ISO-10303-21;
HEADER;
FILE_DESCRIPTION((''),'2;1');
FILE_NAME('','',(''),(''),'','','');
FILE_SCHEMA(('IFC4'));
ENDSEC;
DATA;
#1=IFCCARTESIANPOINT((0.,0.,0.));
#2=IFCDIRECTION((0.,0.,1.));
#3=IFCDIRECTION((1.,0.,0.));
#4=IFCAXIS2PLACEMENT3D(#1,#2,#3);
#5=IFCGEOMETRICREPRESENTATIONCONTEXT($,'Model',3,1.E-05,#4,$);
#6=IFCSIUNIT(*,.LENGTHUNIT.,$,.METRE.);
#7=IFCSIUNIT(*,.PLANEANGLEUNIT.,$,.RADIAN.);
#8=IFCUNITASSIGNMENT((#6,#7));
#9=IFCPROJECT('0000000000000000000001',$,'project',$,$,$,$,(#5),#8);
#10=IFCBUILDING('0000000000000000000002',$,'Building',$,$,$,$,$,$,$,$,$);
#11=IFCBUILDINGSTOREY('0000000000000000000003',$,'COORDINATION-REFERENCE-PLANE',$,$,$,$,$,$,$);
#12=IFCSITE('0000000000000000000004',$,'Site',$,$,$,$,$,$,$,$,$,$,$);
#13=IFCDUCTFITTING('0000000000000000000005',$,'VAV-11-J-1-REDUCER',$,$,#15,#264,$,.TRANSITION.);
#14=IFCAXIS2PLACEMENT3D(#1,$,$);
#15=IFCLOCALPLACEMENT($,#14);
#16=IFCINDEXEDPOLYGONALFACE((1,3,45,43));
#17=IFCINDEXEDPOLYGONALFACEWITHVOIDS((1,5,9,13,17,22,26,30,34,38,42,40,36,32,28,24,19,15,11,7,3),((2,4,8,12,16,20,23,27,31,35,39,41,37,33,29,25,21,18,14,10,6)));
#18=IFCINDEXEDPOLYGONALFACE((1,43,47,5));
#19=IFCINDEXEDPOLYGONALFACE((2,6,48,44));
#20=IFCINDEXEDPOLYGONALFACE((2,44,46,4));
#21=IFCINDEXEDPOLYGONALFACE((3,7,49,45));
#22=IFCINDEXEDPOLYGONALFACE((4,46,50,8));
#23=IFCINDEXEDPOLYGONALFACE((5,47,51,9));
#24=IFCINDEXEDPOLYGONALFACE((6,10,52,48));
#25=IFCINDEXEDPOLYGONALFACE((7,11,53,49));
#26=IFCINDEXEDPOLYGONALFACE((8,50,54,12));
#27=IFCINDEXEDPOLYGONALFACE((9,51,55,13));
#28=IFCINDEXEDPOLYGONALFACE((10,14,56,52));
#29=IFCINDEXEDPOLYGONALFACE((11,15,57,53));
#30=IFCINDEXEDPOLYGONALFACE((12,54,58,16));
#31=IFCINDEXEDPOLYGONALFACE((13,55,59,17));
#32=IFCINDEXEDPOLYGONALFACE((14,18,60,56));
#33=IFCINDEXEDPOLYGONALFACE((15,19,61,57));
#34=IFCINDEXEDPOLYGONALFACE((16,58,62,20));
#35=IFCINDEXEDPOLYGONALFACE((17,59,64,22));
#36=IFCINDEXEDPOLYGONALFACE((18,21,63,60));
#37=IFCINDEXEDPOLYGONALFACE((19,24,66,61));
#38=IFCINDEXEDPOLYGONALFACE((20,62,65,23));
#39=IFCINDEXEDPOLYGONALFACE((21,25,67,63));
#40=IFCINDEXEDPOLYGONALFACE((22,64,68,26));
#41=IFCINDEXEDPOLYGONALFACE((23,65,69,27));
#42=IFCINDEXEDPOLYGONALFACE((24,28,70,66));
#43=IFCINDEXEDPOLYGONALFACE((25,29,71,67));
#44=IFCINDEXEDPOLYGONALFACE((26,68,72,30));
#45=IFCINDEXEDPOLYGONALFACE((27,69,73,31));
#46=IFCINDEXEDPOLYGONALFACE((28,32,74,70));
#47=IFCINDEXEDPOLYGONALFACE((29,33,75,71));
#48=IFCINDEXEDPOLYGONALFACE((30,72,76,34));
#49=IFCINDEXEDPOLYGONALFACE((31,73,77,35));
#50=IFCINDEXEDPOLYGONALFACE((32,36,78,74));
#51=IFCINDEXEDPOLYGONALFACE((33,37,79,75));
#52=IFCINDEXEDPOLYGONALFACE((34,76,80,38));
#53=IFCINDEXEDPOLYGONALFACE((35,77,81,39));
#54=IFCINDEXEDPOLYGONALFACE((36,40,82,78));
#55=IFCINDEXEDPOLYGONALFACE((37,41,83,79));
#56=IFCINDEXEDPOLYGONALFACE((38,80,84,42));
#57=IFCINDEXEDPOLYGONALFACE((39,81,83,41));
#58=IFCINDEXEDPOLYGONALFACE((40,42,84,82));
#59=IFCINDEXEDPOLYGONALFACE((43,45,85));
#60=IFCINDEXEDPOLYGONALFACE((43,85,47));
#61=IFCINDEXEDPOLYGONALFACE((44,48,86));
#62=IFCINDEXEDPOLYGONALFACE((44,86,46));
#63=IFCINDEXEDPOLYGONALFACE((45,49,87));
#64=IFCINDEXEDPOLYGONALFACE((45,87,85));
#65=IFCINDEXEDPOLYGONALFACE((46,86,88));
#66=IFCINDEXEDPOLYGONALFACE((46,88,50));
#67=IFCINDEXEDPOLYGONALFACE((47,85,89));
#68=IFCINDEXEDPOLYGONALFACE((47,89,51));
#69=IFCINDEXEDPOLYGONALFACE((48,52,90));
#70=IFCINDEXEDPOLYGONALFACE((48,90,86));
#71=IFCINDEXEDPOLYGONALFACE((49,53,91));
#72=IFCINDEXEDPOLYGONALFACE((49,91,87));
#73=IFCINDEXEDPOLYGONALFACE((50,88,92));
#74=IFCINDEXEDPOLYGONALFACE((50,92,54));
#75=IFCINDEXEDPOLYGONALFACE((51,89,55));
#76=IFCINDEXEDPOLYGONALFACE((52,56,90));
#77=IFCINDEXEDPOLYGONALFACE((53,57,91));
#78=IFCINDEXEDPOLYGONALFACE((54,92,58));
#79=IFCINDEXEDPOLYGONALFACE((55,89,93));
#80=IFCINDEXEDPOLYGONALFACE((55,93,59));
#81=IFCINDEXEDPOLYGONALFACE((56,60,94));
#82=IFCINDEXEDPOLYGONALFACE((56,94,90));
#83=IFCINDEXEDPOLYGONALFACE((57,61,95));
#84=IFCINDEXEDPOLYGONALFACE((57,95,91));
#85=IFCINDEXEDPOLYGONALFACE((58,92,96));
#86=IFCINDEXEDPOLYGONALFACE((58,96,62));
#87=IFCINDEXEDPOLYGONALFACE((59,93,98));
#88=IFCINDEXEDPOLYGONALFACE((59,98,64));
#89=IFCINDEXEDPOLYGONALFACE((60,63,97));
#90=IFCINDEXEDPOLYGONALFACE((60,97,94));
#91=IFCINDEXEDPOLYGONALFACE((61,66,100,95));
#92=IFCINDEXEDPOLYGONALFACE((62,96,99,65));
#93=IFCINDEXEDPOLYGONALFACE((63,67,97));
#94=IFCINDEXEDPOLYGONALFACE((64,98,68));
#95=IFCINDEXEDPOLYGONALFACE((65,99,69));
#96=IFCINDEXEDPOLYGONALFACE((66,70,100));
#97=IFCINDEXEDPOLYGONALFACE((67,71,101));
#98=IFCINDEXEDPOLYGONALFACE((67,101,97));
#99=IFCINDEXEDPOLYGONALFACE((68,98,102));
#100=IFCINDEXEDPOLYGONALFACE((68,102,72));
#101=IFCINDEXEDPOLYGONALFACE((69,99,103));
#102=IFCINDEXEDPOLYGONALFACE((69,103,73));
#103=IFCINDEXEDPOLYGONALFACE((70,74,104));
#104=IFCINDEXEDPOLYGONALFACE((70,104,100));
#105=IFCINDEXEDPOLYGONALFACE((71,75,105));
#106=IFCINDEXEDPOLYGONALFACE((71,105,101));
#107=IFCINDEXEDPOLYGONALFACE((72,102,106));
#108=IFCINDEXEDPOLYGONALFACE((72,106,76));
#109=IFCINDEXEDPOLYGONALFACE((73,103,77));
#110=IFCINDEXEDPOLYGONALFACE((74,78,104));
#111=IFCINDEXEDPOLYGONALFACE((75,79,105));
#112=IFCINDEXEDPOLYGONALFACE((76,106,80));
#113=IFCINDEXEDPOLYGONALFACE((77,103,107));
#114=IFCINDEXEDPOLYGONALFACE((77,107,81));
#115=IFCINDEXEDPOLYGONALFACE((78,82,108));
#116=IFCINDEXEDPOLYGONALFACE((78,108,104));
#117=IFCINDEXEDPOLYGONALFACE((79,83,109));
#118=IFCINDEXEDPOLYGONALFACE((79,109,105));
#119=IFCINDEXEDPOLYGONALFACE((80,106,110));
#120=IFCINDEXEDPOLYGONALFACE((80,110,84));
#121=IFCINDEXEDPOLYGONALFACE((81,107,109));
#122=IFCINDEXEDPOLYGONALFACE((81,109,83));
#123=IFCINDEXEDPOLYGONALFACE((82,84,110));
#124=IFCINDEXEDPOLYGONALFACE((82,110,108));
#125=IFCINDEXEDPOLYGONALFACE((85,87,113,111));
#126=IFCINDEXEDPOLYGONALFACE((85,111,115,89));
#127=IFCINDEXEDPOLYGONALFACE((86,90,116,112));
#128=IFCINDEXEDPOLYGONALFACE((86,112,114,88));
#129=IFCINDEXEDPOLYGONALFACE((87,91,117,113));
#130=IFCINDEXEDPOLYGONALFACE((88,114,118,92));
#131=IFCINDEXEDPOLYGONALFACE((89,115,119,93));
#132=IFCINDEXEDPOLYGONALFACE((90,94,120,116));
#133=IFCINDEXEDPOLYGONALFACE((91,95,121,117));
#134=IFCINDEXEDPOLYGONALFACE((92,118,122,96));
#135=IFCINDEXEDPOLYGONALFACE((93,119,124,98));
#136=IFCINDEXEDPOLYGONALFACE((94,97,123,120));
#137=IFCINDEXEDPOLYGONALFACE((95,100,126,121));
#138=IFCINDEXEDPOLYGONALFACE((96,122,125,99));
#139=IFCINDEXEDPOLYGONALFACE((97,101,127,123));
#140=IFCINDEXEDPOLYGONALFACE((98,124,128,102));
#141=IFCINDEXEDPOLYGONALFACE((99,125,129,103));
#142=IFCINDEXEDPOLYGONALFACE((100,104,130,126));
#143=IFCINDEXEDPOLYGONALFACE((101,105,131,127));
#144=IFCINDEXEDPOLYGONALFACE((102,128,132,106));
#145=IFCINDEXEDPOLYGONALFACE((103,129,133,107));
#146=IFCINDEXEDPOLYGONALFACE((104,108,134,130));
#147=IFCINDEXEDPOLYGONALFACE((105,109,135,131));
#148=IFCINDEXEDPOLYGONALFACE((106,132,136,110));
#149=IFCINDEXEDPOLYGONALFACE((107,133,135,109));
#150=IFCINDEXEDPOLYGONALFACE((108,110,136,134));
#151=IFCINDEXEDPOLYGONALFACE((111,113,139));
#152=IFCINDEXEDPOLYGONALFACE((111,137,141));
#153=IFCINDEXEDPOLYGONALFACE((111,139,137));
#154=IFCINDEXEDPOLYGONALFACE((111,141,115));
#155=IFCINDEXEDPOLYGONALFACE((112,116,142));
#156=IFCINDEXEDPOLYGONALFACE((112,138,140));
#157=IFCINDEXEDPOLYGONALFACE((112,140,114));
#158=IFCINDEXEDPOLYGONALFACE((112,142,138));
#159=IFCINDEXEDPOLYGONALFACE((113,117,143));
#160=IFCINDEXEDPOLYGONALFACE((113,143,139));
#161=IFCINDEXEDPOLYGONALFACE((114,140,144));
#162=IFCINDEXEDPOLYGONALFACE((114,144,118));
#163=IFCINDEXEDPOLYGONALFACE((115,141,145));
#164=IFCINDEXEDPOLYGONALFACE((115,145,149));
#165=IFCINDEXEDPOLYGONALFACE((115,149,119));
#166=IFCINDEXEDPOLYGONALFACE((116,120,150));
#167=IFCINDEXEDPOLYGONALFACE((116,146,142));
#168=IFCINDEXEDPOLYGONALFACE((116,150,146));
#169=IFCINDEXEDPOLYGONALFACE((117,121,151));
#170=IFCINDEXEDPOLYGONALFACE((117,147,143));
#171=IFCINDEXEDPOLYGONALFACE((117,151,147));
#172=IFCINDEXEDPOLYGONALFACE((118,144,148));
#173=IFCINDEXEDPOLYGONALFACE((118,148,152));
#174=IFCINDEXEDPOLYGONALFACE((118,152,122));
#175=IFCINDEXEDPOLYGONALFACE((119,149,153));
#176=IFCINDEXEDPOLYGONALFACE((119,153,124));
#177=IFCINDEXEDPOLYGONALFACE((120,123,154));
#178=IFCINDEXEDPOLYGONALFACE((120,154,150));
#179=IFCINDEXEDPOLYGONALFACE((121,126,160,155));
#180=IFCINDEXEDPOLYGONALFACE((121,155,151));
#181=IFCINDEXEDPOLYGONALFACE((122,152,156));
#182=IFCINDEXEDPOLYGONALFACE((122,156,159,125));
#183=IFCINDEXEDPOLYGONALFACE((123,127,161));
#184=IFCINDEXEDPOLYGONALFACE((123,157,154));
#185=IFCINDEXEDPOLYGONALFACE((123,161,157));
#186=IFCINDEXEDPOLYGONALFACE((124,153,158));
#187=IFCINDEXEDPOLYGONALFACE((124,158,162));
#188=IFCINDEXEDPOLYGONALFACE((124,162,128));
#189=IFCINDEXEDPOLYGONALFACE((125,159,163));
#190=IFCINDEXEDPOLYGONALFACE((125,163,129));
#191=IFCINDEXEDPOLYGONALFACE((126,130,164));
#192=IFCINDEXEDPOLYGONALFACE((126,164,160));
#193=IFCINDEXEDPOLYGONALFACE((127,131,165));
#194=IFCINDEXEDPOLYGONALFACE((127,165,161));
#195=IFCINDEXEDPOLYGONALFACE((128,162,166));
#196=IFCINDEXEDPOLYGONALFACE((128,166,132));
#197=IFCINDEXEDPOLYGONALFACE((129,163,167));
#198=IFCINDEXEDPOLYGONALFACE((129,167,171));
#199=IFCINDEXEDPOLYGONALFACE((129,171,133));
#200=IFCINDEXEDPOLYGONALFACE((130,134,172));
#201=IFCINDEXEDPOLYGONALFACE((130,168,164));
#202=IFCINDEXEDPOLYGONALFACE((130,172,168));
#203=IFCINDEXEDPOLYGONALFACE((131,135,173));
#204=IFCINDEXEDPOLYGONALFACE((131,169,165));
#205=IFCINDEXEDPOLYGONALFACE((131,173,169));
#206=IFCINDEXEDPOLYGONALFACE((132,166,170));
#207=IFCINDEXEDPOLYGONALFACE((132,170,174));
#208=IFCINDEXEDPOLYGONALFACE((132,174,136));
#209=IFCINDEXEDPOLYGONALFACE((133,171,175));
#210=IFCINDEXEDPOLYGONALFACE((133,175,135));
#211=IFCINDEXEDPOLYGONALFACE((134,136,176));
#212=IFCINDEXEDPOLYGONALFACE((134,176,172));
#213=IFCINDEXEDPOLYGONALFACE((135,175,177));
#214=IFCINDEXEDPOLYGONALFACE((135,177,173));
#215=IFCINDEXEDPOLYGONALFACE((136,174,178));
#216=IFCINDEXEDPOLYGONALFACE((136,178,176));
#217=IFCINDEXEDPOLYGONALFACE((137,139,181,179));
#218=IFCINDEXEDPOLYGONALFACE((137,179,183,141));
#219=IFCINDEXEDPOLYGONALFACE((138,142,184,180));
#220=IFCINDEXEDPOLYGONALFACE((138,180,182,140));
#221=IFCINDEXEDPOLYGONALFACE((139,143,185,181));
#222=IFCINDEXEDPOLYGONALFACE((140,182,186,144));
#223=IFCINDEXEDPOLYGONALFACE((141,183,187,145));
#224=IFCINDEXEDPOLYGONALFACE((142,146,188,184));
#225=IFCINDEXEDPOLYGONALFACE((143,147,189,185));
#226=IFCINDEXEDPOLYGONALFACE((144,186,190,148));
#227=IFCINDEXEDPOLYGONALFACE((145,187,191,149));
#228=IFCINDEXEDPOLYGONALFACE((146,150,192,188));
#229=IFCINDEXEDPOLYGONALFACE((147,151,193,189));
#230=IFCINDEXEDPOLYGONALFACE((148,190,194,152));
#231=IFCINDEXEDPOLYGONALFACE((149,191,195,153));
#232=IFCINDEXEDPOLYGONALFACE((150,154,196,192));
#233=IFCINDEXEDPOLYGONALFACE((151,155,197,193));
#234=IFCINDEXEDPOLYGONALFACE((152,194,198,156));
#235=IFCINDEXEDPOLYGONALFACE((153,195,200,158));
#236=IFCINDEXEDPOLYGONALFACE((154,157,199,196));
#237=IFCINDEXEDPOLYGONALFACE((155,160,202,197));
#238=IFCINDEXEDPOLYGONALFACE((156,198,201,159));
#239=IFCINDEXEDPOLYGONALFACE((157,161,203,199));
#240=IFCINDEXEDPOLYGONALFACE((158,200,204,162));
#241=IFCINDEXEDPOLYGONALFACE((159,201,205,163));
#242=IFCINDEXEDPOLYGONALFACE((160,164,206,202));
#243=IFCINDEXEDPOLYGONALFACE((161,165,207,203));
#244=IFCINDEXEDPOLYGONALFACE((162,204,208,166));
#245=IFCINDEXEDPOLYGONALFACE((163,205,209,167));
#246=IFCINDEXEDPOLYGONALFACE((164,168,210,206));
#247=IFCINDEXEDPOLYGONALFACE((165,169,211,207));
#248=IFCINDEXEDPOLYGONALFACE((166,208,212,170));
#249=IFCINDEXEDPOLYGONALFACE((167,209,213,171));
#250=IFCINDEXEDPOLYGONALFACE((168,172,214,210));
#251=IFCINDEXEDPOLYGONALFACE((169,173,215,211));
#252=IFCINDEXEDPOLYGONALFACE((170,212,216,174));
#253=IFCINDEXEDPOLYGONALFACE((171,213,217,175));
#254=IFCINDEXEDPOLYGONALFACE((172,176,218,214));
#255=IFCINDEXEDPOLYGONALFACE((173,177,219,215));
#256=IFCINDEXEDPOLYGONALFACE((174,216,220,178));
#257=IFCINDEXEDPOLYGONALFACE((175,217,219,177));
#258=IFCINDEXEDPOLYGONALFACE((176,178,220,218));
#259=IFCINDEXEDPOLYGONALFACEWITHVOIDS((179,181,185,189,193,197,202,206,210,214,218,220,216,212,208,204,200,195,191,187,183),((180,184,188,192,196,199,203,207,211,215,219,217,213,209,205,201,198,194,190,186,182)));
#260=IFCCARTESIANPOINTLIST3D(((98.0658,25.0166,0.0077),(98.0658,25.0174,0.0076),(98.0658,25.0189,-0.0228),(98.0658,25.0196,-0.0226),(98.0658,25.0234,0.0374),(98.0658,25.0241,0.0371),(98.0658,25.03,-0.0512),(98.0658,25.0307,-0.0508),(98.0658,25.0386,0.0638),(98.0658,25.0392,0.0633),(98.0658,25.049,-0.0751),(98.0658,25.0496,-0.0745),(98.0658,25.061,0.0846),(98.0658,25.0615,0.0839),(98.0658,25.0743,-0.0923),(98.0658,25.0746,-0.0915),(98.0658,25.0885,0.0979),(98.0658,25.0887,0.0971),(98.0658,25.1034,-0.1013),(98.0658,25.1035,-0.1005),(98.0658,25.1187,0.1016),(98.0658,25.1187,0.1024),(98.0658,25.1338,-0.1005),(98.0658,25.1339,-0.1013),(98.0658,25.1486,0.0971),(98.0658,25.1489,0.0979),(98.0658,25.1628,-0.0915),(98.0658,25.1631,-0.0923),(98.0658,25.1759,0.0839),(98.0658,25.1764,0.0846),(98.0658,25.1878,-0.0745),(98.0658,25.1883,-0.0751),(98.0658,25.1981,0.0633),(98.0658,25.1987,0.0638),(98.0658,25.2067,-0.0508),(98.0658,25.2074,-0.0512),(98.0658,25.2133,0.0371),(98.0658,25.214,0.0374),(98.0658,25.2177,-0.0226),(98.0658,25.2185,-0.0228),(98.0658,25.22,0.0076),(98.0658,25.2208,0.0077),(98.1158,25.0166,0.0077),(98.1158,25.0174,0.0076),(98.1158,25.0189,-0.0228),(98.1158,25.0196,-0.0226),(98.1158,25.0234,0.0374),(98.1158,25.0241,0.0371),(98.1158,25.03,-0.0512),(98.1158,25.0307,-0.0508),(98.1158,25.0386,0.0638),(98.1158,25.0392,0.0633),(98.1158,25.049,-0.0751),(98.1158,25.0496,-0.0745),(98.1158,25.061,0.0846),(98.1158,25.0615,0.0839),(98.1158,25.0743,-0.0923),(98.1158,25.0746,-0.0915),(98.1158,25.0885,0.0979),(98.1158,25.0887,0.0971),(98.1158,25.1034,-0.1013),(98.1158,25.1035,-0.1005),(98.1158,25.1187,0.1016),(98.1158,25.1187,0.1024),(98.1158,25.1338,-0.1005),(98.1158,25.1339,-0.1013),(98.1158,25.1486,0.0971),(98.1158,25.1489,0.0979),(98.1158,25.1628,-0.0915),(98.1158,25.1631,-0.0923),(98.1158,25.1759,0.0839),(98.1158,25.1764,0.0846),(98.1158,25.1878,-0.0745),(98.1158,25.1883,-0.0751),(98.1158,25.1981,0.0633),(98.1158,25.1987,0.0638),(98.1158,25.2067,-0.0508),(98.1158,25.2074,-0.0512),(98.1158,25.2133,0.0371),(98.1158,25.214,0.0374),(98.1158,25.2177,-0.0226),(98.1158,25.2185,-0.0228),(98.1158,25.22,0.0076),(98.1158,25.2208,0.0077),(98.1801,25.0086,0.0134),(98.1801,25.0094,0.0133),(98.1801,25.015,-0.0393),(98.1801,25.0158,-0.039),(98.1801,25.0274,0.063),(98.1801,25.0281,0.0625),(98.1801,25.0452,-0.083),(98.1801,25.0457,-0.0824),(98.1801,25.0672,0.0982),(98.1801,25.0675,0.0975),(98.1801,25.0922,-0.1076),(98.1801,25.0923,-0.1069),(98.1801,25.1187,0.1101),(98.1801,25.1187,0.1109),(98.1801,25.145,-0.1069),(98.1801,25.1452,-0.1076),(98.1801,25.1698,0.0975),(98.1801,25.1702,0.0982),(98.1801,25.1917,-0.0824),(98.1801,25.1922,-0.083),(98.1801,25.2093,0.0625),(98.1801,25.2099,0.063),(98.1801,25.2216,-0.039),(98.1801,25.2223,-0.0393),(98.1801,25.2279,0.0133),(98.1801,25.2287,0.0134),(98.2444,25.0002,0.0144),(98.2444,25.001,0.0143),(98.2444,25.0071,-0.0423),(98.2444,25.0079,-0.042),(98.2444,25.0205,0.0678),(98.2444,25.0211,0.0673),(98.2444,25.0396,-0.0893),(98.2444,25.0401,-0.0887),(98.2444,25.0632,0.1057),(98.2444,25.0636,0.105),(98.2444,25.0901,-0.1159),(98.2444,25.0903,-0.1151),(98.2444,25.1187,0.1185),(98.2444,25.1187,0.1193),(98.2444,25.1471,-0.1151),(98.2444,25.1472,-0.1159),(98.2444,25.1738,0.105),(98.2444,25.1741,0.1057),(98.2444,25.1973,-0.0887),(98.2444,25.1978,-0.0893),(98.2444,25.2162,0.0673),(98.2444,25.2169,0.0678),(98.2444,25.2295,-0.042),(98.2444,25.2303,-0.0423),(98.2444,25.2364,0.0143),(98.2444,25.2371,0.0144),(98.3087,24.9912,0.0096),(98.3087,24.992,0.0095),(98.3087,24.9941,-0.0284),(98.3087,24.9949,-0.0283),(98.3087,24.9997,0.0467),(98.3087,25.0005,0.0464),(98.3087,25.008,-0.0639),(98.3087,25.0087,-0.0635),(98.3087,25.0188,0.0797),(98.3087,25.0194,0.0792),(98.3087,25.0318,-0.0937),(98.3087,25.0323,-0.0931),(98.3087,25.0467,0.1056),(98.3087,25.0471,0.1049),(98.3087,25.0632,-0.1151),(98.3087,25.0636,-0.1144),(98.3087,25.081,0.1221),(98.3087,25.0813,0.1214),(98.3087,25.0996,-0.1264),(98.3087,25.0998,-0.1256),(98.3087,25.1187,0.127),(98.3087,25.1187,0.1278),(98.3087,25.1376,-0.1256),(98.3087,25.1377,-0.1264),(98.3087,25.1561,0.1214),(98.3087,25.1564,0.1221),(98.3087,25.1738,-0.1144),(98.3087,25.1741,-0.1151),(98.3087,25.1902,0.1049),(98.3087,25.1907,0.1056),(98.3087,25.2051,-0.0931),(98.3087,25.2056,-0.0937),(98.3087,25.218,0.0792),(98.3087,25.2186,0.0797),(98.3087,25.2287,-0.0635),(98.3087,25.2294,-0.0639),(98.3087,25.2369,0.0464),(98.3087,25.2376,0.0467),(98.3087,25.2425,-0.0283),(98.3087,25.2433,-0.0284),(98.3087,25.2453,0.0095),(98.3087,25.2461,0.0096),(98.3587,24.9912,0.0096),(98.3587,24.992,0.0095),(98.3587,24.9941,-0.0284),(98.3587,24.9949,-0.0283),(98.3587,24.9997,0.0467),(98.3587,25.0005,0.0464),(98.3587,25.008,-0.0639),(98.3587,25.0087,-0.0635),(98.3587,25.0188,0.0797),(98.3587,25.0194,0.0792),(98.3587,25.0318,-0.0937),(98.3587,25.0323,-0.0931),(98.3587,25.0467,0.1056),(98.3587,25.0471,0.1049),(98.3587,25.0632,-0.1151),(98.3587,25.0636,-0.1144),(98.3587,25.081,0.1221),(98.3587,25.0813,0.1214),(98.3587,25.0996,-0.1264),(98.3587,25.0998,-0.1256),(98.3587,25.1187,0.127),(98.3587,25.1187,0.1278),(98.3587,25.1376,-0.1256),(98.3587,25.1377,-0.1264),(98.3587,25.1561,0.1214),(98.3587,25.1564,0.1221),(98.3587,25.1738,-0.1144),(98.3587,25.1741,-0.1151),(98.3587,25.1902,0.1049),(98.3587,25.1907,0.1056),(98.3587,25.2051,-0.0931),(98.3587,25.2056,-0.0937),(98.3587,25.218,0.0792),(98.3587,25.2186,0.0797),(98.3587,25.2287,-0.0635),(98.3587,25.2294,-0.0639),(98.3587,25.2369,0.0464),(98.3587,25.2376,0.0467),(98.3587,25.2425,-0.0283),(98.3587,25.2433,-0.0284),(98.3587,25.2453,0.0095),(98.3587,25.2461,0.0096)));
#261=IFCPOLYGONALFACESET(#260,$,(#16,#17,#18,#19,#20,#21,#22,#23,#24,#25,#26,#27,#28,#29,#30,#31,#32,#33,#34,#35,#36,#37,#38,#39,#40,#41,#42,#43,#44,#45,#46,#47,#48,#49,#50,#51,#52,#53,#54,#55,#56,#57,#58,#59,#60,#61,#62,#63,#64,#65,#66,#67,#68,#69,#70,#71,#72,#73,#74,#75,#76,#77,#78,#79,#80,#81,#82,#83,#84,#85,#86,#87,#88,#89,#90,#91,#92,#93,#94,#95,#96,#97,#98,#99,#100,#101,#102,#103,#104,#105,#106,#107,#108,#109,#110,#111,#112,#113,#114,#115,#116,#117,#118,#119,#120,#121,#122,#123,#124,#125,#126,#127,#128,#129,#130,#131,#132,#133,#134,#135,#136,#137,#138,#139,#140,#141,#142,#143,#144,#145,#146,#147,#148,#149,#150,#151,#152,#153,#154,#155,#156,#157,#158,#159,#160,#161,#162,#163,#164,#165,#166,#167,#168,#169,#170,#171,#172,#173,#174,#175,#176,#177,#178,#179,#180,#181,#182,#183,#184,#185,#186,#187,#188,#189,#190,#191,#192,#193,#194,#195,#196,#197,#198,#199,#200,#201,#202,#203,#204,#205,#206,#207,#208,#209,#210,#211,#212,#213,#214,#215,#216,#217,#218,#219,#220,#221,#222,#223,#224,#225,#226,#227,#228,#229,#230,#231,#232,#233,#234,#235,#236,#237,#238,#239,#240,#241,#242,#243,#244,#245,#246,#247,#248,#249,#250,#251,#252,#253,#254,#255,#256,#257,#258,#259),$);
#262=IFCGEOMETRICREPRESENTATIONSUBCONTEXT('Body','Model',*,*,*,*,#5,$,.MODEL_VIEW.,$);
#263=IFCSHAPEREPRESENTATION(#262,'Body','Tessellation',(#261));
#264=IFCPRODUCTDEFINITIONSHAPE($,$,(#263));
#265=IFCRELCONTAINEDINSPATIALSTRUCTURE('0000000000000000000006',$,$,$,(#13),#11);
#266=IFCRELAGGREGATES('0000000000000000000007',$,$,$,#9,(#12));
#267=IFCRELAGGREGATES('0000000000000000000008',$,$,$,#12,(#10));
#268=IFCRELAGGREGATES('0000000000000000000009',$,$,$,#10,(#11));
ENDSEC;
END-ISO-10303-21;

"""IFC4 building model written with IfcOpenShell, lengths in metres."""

from ifc_helpers import new_model, entity, si_unit, frame, origin_with_axes, place, context, subcontext, project, spatial, element, save


model = new_model("IFC4")

# Units and contexts
model_context_1 = context("Model", 3, precision=1e-05, world=origin_with_axes())
body_context_1 = subcontext(model_context_1, "Body", "Model", "MODEL_VIEW")
ifc_project = project(units=[si_unit("LENGTHUNIT", "METRE"), si_unit("PLANEANGLEUNIT", "RADIAN")], contexts=[model_context_1])

# Site, building, storey
site = spatial("IfcSite", under=ifc_project, Name="Site")
building = spatial("IfcBuilding", under=site, Name="Building")
storey = spatial("IfcBuildingStorey", under=building, Name="COORDINATION-REFERENCE-PLANE")

# Duct fitting
for number, where, z_axis, x_axis, name in (
    (1, (98.3587, 25.1187, 0.0), (0.0, -1.0, 0.0), (0.0, 0.0, 1.0), "VAV-11-J-1-REDUCER"),
):
    element("IfcDuctFitting", number, at=place(None, frame(where, z_axis=z_axis, x_axis=x_axis)), inside=storey, Name=name, PredefinedType="TRANSITION", context=body_context_1, shape_type="SweptSolid", body=[
        entity("IfcRevolvedAreaSolid", entity("IfcArbitraryClosedProfileDef", "AREA", None, entity("IfcPolyline", [entity("IfcCartesianPoint", [0.1278, 0.0]), entity("IfcCartesianPoint", [0.1278, 0.05]), entity("IfcCartesianPoint", [0.1024, 0.2429]), entity("IfcCartesianPoint", [0.1024, 0.2929]), entity("IfcCartesianPoint", [0.1016, 0.2929]), entity("IfcCartesianPoint", [0.1016, 0.2429]), entity("IfcCartesianPoint", [0.127, 0.05]), entity("IfcCartesianPoint", [0.127, 0.0]), entity("IfcCartesianPoint", [0.1278, 0.0])])), entity("IfcAxis2Placement3D", entity("IfcCartesianPoint", [0.0, 0.0, 0.0])), entity("IfcAxis1Placement", entity("IfcCartesianPoint", [0.0, 0.0, 0.0]), entity("IfcDirection", [0.0, 1.0, 0.0])), 6.283185),
    ])

save(model, "model.ifc")
